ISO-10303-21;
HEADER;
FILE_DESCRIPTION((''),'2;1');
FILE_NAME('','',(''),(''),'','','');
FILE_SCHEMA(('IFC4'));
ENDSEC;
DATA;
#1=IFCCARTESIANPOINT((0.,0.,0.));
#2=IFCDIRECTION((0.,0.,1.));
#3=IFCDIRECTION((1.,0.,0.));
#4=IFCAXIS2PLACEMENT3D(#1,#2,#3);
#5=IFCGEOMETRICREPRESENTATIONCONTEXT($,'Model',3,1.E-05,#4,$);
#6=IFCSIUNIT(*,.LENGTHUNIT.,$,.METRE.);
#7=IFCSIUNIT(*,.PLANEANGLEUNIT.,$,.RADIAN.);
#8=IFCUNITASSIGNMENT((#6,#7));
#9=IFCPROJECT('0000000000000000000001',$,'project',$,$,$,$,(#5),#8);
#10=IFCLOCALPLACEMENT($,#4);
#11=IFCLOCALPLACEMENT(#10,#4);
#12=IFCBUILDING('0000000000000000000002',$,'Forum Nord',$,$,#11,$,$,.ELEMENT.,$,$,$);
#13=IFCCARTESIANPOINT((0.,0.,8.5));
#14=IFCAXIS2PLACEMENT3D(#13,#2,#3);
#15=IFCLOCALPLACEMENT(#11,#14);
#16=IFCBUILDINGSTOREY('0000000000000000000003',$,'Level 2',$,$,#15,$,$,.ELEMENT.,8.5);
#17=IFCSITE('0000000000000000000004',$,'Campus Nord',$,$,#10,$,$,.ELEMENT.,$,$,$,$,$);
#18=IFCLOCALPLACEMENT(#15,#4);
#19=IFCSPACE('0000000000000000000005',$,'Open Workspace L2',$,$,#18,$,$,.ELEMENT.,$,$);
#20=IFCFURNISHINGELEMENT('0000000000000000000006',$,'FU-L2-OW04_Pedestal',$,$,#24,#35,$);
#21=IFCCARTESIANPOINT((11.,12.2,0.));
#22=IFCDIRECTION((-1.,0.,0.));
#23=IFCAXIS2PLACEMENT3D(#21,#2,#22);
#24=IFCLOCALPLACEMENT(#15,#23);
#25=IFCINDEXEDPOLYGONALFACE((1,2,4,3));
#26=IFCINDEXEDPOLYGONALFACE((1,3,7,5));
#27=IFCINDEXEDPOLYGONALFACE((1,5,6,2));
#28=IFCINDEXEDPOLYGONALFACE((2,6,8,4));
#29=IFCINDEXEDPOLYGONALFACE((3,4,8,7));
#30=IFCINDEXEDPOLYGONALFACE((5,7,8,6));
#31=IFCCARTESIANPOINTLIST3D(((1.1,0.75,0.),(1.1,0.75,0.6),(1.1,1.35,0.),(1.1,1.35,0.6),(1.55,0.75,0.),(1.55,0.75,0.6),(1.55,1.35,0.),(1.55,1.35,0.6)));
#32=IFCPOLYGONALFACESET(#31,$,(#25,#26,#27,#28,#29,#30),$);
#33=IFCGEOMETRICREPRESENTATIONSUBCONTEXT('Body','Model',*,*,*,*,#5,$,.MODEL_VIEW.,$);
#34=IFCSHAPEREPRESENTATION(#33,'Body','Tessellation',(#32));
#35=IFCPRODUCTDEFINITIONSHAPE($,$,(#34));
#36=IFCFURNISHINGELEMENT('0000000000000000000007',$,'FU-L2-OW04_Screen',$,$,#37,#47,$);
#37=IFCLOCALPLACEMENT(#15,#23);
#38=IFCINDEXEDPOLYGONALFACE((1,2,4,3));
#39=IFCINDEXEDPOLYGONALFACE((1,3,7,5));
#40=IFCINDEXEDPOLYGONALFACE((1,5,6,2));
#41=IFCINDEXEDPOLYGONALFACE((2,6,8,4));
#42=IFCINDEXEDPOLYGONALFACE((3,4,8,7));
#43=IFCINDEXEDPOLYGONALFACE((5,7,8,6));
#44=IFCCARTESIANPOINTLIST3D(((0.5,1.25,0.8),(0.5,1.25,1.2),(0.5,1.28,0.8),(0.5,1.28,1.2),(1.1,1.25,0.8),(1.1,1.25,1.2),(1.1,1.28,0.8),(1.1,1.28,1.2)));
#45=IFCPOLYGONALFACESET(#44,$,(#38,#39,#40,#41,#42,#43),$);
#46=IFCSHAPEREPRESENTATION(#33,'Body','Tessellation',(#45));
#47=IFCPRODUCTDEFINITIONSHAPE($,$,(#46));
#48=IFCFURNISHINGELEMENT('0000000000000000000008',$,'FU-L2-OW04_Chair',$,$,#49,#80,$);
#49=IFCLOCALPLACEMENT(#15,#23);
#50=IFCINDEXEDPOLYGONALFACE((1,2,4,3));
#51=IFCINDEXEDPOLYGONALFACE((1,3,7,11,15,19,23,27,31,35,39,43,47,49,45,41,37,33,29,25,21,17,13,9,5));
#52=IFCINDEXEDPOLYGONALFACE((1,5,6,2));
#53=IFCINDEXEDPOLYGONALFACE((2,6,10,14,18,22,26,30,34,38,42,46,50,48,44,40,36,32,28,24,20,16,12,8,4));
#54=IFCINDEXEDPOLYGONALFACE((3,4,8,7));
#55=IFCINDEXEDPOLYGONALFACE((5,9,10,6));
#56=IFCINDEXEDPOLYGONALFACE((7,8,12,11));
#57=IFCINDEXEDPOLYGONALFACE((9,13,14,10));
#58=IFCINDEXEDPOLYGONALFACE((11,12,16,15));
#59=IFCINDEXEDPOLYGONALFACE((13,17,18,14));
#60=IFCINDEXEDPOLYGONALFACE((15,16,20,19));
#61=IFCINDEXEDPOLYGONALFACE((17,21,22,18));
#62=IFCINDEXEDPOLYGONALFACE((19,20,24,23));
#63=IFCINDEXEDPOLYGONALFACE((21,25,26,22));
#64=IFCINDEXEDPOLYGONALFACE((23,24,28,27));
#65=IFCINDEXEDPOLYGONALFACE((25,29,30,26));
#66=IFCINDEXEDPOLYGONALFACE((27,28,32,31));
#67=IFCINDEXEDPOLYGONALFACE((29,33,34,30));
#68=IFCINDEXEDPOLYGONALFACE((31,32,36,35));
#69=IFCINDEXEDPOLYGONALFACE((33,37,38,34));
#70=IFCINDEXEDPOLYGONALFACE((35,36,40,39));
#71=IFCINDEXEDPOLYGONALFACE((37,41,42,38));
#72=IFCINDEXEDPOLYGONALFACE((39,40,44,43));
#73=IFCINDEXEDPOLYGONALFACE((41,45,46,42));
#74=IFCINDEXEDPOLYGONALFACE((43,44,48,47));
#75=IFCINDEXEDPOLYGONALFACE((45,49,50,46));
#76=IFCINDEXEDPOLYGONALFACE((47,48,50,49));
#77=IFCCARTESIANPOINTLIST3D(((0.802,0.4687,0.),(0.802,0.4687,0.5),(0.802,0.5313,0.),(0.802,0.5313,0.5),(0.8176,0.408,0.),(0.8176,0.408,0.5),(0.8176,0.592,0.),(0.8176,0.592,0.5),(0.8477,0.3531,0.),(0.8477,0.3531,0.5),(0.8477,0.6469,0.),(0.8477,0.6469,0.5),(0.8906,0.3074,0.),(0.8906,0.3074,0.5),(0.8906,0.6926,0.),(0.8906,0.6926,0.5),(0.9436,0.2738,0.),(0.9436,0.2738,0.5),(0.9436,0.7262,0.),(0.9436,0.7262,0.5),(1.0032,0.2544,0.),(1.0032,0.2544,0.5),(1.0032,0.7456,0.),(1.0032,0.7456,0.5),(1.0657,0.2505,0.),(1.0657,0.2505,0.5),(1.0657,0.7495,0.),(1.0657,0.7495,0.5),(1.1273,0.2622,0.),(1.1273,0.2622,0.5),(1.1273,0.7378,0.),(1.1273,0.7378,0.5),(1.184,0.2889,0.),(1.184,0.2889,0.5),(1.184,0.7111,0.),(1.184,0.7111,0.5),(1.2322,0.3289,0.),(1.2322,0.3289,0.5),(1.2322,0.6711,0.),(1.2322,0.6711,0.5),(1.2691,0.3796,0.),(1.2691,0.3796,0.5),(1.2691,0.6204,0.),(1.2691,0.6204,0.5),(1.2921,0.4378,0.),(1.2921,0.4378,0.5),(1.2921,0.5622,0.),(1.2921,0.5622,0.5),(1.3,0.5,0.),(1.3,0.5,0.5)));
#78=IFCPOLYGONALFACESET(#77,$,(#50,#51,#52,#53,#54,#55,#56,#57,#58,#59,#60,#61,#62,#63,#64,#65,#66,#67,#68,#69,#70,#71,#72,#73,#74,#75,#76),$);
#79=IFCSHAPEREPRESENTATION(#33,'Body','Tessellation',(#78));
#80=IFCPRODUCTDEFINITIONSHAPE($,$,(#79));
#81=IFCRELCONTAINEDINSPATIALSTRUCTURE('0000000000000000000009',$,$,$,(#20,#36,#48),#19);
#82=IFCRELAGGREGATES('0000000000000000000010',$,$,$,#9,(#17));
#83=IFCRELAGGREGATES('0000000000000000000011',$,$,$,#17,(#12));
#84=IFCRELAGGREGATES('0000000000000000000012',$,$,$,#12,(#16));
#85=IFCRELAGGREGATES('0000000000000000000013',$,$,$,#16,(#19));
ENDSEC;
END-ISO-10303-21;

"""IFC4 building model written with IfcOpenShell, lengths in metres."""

from ifc_helpers import new_model, si_unit, frame, frame_2d, origin_with_axes, place, context, subcontext, project, spatial, rectangle, circle, extrude, element, save


model = new_model("IFC4")

# Units and contexts
model_context = context("Model", 3, precision=1e-05, world=origin_with_axes())
body_context = subcontext(model_context, "Body", "Model", "MODEL_VIEW")
ifc_project = project(units=[si_unit("LENGTHUNIT", "METRE"), si_unit("PLANEANGLEUNIT", "RADIAN")], contexts=[model_context])

# Site, building, storey, space
site_placement = place(None, origin_with_axes())
site = spatial("IfcSite", under=ifc_project, at=site_placement, Name="Campus Nord", CompositionType="ELEMENT")
building_placement = place(site_placement, origin_with_axes())
building = spatial("IfcBuilding", under=site, at=building_placement, Name="Forum Nord", CompositionType="ELEMENT")
storey_placement = place(building_placement, frame((0.0, 0.0, 8.5), z_axis=(0.0, 0.0, 1.0), x_axis=(1.0, 0.0, 0.0)))
storey = spatial("IfcBuildingStorey", under=building, at=storey_placement, Name="Level 2", CompositionType="ELEMENT", Elevation=8.5)
space_placement = place(storey_placement, origin_with_axes())
space = spatial("IfcSpace", under=storey, at=space_placement, Name="Open Workspace L2", CompositionType="ELEMENT")

# Furnishing elements
furnishing_1_placement = place(storey_placement, frame((11.0, 12.2, 0.0), z_axis=(0.0, 0.0, 1.0), x_axis=(-1.0, 0.0, 0.0)))
element("IfcFurnishingElement", 1, at=furnishing_1_placement, inside=space, Name="FU-L2-OW04_Pedestal", context=body_context, shape_type="SweptSolid", body=[
    extrude(rectangle(XDim=0.45, YDim=0.6, at=frame_2d((1.325, 1.05), x_axis=(1.0, 0.0))), origin_with_axes(), (0.0, 0.0, 1.0), 0.6),
])
furnishing_2_placement = place(storey_placement, frame((11.0, 12.2, 0.0), z_axis=(0.0, 0.0, 1.0), x_axis=(-1.0, 0.0, 0.0)))
element("IfcFurnishingElement", 2, at=furnishing_2_placement, inside=space, Name="FU-L2-OW04_Screen", context=body_context, shape_type="SweptSolid", body=[
    extrude(rectangle(XDim=0.6, YDim=0.03, at=frame_2d((0.8, 1.265), x_axis=(1.0, 0.0))), frame((0.0, 0.0, 0.8), z_axis=(0.0, 0.0, 1.0), x_axis=(1.0, 0.0, 0.0)), (0.0, 0.0, 1.0), 0.4),
])
furnishing_3_placement = place(storey_placement, frame((11.0, 12.2, 0.0), z_axis=(0.0, 0.0, 1.0), x_axis=(-1.0, 0.0, 0.0)))
element("IfcFurnishingElement", 3, at=furnishing_3_placement, inside=space, Name="FU-L2-OW04_Chair", context=body_context, shape_type="SweptSolid", body=[
    extrude(circle(Radius=0.25, at=frame_2d((1.05, 0.5), x_axis=(1.0, 0.0))), origin_with_axes(), (0.0, 0.0, 1.0), 0.5),
])

save(model, "model.ifc")
